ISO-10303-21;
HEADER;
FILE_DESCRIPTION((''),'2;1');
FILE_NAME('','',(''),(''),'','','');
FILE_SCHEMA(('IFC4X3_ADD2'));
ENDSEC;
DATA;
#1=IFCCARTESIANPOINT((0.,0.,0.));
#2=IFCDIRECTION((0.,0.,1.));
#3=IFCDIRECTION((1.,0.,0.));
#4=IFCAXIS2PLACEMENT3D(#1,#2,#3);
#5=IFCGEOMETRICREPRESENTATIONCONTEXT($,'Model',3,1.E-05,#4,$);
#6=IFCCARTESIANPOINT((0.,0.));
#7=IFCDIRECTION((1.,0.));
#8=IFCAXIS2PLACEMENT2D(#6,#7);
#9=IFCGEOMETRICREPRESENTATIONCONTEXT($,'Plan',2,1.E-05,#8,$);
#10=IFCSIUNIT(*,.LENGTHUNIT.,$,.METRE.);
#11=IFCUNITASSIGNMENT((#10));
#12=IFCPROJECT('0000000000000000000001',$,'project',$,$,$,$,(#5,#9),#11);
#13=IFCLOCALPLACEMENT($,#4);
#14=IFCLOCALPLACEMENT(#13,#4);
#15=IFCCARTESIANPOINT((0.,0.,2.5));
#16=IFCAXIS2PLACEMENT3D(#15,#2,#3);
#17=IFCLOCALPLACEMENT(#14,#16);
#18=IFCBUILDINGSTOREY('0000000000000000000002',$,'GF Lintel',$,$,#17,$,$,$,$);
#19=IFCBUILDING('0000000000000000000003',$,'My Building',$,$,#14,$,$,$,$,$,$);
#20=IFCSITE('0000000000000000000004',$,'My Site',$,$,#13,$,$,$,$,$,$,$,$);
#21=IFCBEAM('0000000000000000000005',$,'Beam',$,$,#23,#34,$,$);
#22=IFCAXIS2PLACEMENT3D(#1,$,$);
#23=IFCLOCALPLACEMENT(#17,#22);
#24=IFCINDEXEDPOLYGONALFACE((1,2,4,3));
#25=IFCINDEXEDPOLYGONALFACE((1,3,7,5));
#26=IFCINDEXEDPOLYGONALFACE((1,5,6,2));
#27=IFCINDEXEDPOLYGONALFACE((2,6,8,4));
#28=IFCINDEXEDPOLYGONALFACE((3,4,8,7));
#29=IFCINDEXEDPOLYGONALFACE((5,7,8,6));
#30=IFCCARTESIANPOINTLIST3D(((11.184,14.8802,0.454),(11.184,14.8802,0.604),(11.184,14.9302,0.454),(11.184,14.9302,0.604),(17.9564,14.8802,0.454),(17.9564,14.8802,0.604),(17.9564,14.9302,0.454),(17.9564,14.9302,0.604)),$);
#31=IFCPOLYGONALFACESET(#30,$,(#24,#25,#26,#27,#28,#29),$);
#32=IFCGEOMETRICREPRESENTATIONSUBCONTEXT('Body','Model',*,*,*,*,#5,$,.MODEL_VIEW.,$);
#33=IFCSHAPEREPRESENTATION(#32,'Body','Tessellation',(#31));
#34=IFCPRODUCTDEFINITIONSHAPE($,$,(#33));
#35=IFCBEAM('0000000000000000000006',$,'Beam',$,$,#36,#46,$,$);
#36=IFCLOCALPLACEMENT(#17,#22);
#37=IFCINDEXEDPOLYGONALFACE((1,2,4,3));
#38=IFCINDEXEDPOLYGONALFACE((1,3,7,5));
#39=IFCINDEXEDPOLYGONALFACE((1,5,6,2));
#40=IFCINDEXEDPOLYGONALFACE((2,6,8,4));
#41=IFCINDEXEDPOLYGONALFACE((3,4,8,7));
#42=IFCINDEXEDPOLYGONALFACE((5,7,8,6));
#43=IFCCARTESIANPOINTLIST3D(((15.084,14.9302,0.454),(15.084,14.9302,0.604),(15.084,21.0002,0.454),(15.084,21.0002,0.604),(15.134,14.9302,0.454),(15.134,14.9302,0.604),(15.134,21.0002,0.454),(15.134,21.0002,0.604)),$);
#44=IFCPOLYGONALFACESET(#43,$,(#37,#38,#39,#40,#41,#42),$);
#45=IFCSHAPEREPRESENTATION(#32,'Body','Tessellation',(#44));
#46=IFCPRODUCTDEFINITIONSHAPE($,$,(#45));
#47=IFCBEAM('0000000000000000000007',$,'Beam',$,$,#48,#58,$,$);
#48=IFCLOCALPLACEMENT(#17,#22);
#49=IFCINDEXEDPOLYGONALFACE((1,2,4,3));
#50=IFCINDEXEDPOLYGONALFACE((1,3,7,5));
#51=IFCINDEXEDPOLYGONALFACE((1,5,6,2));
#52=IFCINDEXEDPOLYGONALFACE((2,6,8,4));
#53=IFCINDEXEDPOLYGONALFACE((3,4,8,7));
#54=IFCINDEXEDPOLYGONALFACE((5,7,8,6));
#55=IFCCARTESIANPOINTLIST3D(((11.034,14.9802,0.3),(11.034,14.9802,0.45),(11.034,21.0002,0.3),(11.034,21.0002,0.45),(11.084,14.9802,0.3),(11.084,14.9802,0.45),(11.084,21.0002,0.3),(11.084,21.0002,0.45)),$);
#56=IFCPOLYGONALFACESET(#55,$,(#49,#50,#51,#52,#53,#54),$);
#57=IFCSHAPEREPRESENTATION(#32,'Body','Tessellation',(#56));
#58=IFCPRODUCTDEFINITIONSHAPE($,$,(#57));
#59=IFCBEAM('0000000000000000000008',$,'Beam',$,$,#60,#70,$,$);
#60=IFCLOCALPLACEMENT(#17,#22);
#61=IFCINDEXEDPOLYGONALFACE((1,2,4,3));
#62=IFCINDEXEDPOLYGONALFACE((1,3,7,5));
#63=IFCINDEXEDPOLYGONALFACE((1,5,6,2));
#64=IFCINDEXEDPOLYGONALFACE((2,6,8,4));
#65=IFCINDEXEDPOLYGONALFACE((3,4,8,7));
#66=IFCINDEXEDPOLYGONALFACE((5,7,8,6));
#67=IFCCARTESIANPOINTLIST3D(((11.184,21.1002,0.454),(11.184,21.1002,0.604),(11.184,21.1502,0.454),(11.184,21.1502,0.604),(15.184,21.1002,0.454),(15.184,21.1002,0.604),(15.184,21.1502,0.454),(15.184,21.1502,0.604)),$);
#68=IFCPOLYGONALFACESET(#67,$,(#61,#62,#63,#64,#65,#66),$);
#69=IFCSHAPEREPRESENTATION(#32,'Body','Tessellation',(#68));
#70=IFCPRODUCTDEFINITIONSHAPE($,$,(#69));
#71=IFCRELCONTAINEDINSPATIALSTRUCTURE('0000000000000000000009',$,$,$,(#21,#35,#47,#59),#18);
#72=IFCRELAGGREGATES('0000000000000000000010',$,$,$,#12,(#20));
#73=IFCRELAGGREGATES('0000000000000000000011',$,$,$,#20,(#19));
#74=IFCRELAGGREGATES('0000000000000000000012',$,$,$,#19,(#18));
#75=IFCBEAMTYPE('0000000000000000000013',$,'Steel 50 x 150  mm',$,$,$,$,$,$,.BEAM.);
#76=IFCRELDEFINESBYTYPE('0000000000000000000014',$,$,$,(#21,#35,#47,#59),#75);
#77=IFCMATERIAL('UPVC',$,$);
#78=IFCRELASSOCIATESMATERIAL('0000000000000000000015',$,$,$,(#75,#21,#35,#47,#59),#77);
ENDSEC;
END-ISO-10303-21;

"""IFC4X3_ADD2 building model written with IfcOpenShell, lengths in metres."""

from ifc_helpers import new_model, si_unit, frame, origin_with_axes, origin_2d_with_axis, place, context, subcontext, project, spatial, rectangle, extrude, material, material_profile, profile_set, profile_usage, type_object, element, save


model = new_model("IFC4X3_ADD2")

# Units and contexts
model_context = context("Model", 3, precision=1e-05, world=origin_with_axes())
plan_context = context("Plan", 2, precision=1e-05, world=origin_2d_with_axis())
body_context = subcontext(model_context, "Body", "Model", "MODEL_VIEW")
ifc_project = project(units=[si_unit("LENGTHUNIT", "METRE")], contexts=[model_context, plan_context])

# Site, building, storey
site_placement = place(None, origin_with_axes())
site = spatial("IfcSite", under=ifc_project, at=site_placement, Name="My Site")
building_placement = place(site_placement, origin_with_axes())
building = spatial("IfcBuilding", under=site, at=building_placement, Name="My Building")
storey_placement = place(building_placement, frame((0.0, 0.0, 2.5), z_axis=(0.0, 0.0, 1.0), x_axis=(1.0, 0.0, 0.0)))
storey = spatial("IfcBuildingStorey", under=building, at=storey_placement, Name="GF Lintel")

# Beams
ifc_material = material(Name="UPVC")
ifc_material_profile = material_profile(ifc_material, rectangle(XDim=0.05, YDim=0.15))
ifc_profile_set = profile_set([ifc_material_profile])
ifc_profile_usage_1 = profile_usage(ifc_profile_set)
beam_type = type_object("IfcBeamType", Name="Steel 50 x 150  mm", PredefinedType="BEAM", material=ifc_profile_set)
beam_1_placement = place(storey_placement, frame((11.184, 14.9052, 0.529), z_axis=(1.0, 0.0, 0.0), x_axis=(0.0, 1.0, 0.0)))
element("IfcBeam", 1, at=beam_1_placement, inside=storey, type_object=beam_type, material=ifc_profile_usage_1, Name="Beam", context=body_context, shape_type="SweptSolid", body=[
    extrude(rectangle(XDim=0.05, YDim=0.15), origin_with_axes(), (0.0, 0.0, 1.0), 6.7724),
])
ifc_profile_usage_2 = profile_usage(ifc_profile_set)
beam_2_placement = place(storey_placement, frame((15.109, 14.9302, 0.529), z_axis=(0.0, 1.0, 0.0), x_axis=(-1.0, 0.0, 0.0)))
element("IfcBeam", 2, at=beam_2_placement, inside=storey, type_object=beam_type, material=ifc_profile_usage_2, Name="Beam", context=body_context, shape_type="SweptSolid", body=[
    extrude(rectangle(XDim=0.05, YDim=0.15), origin_with_axes(), (0.0, 0.0, 1.0), 6.07),
])
ifc_profile_usage_3 = profile_usage(ifc_profile_set)
beam_3_placement = place(storey_placement, frame((11.059, 14.9802, 0.375), z_axis=(0.0, 1.0, 0.0), x_axis=(-1.0, 0.0, 0.0)))
element("IfcBeam", 3, at=beam_3_placement, inside=storey, type_object=beam_type, material=ifc_profile_usage_3, Name="Beam", context=body_context, shape_type="SweptSolid", body=[
    extrude(rectangle(XDim=0.05, YDim=0.15), origin_with_axes(), (0.0, 0.0, 1.0), 6.02),
])
ifc_profile_usage_4 = profile_usage(ifc_profile_set)
beam_4_placement = place(storey_placement, frame((11.184, 21.1252, 0.529), z_axis=(1.0, 0.0, 0.0), x_axis=(0.0, 1.0, 0.0)))
element("IfcBeam", 4, at=beam_4_placement, inside=storey, type_object=beam_type, material=ifc_profile_usage_4, Name="Beam", context=body_context, shape_type="SweptSolid", body=[
    extrude(rectangle(XDim=0.05, YDim=0.15), origin_with_axes(), (0.0, 0.0, 1.0), 4.0),
])

save(model, "model.ifc")
